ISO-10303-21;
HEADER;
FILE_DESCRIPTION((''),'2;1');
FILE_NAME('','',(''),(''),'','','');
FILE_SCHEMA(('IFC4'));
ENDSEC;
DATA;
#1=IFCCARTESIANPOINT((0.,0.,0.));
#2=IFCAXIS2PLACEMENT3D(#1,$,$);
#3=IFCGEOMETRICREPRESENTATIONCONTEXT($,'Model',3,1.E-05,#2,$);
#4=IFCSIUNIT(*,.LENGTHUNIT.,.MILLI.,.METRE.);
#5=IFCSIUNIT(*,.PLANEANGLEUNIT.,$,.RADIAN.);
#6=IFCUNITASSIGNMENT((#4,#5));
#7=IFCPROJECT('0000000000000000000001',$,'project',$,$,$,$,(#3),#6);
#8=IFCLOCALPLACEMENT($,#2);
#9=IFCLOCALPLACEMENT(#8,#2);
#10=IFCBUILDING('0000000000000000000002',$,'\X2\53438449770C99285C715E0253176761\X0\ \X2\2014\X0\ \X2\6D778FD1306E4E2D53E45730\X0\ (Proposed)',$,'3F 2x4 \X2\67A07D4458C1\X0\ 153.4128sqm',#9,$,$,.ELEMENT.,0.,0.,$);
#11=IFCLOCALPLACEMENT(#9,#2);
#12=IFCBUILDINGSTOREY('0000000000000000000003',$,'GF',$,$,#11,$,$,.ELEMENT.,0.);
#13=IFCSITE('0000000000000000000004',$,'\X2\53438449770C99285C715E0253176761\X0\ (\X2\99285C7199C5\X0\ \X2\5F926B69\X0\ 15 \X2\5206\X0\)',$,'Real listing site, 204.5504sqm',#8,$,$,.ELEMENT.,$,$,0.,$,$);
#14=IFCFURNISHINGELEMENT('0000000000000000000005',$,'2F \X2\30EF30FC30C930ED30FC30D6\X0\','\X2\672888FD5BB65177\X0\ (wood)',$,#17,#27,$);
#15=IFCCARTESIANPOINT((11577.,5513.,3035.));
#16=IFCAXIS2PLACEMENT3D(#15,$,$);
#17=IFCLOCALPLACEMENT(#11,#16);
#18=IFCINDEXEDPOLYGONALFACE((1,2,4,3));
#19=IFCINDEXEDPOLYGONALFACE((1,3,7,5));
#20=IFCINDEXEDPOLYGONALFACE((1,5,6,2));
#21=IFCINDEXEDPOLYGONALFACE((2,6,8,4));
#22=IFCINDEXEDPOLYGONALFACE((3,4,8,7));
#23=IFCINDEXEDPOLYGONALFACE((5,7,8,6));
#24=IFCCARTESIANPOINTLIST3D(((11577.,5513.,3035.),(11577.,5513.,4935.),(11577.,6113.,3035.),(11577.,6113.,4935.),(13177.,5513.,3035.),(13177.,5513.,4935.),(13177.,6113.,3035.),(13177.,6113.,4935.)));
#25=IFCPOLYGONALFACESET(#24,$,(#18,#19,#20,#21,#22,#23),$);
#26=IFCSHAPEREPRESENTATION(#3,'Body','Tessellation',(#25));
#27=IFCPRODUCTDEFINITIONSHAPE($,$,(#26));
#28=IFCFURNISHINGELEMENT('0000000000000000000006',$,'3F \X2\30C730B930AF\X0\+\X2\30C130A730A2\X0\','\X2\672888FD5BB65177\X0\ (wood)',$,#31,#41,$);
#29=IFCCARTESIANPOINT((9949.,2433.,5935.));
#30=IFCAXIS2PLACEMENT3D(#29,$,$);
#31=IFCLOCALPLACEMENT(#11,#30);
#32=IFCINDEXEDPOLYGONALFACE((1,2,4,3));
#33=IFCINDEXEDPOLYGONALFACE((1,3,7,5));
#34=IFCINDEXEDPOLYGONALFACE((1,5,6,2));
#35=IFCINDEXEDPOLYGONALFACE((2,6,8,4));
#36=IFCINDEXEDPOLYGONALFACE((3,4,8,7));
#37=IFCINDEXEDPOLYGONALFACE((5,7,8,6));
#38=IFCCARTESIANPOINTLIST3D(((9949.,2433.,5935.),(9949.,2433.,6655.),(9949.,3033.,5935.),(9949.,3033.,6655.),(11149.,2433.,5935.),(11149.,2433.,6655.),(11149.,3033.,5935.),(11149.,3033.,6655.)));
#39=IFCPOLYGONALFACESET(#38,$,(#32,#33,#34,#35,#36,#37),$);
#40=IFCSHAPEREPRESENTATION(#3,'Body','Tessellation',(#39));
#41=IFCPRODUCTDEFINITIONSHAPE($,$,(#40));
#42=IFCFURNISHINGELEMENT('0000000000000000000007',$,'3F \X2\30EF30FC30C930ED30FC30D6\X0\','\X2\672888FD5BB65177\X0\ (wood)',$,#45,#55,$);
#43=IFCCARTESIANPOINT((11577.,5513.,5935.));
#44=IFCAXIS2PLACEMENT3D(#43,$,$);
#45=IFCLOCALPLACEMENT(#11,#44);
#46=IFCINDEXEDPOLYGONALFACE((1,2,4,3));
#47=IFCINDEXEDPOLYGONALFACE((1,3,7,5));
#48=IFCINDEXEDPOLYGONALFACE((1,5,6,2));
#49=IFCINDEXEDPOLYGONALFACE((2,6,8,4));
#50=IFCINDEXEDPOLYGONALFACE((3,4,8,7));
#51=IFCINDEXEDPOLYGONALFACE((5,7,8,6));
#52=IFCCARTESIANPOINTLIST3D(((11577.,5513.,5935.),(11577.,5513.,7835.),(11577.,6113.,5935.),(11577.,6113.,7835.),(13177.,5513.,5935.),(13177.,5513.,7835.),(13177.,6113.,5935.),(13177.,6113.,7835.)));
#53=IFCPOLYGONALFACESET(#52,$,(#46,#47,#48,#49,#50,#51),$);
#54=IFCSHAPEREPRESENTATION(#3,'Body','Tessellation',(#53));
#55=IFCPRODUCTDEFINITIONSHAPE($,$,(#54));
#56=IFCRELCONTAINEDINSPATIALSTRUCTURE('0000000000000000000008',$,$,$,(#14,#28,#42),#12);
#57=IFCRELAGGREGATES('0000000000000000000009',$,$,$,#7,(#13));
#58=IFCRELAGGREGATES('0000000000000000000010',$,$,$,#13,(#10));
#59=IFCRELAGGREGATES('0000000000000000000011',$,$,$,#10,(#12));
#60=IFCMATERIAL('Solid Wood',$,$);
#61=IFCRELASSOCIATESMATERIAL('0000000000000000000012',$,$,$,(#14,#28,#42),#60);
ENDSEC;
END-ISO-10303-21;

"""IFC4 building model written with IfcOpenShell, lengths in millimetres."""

from ifc_helpers import new_model, si_unit, frame, frame_2d, origin, place, context, project, spatial, rectangle, extrude, material, element, save


model = new_model("IFC4")

# Units and contexts
model_context = context("Model", 3, precision=1e-05, world=origin())
ifc_project = project(units=[si_unit("LENGTHUNIT", "METRE", prefix="MILLI"), si_unit("PLANEANGLEUNIT", "RADIAN")], contexts=[model_context])

# Site, building, storey
site_placement = place(None, origin())
site = spatial("IfcSite", under=ifc_project, at=site_placement, Name="千葉県館山市北条 (館山駅 徒歩 15 分)", ObjectType="Real listing site, 204.5504sqm", CompositionType="ELEMENT", RefElevation=0.0)
building_placement = place(site_placement, origin())
building = spatial("IfcBuilding", under=site, at=building_placement, Name="千葉県館山市北条 — 海近の中古地 (Proposed)", ObjectType="3F 2x4 枠組壁 153.4128sqm", CompositionType="ELEMENT", ElevationOfRefHeight=0.0, ElevationOfTerrain=0.0)
storey_placement = place(building_placement, origin())
storey = spatial("IfcBuildingStorey", under=building, at=storey_placement, Name="GF", CompositionType="ELEMENT", Elevation=0.0)

# Shared definitions
ifc_material_1 = material(Name="Solid Wood")

# Furnishing elements
furnishing_1_placement = place(storey_placement, frame((11577.0, 5513.0, 3035.0)))
element("IfcFurnishingElement", 1, at=furnishing_1_placement, inside=storey, material=ifc_material_1, Name="2F ワードローブ", Description="木製家具 (wood)", context=model_context, shape_type="SweptSolid", body=[
    extrude(rectangle(XDim=1600.0, YDim=600.0, at=frame_2d((800.0, 300.0))), frame((11577.0, 5513.0, 3035.0)), (0.0, 0.0, 1.0), 1900.0),
])
furnishing_2_placement = place(storey_placement, frame((9949.0, 2433.0, 5935.0)))
element("IfcFurnishingElement", 2, at=furnishing_2_placement, inside=storey, material=ifc_material_1, Name="3F デスク+チェア", Description="木製家具 (wood)", context=model_context, shape_type="SweptSolid", body=[
    extrude(rectangle(XDim=1200.0, YDim=600.0, at=frame_2d((600.0, 300.0))), frame((9949.0, 2433.0, 5935.0)), (0.0, 0.0, 1.0), 720.0),
])
furnishing_3_placement = place(storey_placement, frame((11577.0, 5513.0, 5935.0)))
element("IfcFurnishingElement", 3, at=furnishing_3_placement, inside=storey, material=ifc_material_1, Name="3F ワードローブ", Description="木製家具 (wood)", context=model_context, shape_type="SweptSolid", body=[
    extrude(rectangle(XDim=1600.0, YDim=600.0, at=frame_2d((800.0, 300.0))), frame((11577.0, 5513.0, 5935.0)), (0.0, 0.0, 1.0), 1900.0),
])

save(model, "model.ifc")
